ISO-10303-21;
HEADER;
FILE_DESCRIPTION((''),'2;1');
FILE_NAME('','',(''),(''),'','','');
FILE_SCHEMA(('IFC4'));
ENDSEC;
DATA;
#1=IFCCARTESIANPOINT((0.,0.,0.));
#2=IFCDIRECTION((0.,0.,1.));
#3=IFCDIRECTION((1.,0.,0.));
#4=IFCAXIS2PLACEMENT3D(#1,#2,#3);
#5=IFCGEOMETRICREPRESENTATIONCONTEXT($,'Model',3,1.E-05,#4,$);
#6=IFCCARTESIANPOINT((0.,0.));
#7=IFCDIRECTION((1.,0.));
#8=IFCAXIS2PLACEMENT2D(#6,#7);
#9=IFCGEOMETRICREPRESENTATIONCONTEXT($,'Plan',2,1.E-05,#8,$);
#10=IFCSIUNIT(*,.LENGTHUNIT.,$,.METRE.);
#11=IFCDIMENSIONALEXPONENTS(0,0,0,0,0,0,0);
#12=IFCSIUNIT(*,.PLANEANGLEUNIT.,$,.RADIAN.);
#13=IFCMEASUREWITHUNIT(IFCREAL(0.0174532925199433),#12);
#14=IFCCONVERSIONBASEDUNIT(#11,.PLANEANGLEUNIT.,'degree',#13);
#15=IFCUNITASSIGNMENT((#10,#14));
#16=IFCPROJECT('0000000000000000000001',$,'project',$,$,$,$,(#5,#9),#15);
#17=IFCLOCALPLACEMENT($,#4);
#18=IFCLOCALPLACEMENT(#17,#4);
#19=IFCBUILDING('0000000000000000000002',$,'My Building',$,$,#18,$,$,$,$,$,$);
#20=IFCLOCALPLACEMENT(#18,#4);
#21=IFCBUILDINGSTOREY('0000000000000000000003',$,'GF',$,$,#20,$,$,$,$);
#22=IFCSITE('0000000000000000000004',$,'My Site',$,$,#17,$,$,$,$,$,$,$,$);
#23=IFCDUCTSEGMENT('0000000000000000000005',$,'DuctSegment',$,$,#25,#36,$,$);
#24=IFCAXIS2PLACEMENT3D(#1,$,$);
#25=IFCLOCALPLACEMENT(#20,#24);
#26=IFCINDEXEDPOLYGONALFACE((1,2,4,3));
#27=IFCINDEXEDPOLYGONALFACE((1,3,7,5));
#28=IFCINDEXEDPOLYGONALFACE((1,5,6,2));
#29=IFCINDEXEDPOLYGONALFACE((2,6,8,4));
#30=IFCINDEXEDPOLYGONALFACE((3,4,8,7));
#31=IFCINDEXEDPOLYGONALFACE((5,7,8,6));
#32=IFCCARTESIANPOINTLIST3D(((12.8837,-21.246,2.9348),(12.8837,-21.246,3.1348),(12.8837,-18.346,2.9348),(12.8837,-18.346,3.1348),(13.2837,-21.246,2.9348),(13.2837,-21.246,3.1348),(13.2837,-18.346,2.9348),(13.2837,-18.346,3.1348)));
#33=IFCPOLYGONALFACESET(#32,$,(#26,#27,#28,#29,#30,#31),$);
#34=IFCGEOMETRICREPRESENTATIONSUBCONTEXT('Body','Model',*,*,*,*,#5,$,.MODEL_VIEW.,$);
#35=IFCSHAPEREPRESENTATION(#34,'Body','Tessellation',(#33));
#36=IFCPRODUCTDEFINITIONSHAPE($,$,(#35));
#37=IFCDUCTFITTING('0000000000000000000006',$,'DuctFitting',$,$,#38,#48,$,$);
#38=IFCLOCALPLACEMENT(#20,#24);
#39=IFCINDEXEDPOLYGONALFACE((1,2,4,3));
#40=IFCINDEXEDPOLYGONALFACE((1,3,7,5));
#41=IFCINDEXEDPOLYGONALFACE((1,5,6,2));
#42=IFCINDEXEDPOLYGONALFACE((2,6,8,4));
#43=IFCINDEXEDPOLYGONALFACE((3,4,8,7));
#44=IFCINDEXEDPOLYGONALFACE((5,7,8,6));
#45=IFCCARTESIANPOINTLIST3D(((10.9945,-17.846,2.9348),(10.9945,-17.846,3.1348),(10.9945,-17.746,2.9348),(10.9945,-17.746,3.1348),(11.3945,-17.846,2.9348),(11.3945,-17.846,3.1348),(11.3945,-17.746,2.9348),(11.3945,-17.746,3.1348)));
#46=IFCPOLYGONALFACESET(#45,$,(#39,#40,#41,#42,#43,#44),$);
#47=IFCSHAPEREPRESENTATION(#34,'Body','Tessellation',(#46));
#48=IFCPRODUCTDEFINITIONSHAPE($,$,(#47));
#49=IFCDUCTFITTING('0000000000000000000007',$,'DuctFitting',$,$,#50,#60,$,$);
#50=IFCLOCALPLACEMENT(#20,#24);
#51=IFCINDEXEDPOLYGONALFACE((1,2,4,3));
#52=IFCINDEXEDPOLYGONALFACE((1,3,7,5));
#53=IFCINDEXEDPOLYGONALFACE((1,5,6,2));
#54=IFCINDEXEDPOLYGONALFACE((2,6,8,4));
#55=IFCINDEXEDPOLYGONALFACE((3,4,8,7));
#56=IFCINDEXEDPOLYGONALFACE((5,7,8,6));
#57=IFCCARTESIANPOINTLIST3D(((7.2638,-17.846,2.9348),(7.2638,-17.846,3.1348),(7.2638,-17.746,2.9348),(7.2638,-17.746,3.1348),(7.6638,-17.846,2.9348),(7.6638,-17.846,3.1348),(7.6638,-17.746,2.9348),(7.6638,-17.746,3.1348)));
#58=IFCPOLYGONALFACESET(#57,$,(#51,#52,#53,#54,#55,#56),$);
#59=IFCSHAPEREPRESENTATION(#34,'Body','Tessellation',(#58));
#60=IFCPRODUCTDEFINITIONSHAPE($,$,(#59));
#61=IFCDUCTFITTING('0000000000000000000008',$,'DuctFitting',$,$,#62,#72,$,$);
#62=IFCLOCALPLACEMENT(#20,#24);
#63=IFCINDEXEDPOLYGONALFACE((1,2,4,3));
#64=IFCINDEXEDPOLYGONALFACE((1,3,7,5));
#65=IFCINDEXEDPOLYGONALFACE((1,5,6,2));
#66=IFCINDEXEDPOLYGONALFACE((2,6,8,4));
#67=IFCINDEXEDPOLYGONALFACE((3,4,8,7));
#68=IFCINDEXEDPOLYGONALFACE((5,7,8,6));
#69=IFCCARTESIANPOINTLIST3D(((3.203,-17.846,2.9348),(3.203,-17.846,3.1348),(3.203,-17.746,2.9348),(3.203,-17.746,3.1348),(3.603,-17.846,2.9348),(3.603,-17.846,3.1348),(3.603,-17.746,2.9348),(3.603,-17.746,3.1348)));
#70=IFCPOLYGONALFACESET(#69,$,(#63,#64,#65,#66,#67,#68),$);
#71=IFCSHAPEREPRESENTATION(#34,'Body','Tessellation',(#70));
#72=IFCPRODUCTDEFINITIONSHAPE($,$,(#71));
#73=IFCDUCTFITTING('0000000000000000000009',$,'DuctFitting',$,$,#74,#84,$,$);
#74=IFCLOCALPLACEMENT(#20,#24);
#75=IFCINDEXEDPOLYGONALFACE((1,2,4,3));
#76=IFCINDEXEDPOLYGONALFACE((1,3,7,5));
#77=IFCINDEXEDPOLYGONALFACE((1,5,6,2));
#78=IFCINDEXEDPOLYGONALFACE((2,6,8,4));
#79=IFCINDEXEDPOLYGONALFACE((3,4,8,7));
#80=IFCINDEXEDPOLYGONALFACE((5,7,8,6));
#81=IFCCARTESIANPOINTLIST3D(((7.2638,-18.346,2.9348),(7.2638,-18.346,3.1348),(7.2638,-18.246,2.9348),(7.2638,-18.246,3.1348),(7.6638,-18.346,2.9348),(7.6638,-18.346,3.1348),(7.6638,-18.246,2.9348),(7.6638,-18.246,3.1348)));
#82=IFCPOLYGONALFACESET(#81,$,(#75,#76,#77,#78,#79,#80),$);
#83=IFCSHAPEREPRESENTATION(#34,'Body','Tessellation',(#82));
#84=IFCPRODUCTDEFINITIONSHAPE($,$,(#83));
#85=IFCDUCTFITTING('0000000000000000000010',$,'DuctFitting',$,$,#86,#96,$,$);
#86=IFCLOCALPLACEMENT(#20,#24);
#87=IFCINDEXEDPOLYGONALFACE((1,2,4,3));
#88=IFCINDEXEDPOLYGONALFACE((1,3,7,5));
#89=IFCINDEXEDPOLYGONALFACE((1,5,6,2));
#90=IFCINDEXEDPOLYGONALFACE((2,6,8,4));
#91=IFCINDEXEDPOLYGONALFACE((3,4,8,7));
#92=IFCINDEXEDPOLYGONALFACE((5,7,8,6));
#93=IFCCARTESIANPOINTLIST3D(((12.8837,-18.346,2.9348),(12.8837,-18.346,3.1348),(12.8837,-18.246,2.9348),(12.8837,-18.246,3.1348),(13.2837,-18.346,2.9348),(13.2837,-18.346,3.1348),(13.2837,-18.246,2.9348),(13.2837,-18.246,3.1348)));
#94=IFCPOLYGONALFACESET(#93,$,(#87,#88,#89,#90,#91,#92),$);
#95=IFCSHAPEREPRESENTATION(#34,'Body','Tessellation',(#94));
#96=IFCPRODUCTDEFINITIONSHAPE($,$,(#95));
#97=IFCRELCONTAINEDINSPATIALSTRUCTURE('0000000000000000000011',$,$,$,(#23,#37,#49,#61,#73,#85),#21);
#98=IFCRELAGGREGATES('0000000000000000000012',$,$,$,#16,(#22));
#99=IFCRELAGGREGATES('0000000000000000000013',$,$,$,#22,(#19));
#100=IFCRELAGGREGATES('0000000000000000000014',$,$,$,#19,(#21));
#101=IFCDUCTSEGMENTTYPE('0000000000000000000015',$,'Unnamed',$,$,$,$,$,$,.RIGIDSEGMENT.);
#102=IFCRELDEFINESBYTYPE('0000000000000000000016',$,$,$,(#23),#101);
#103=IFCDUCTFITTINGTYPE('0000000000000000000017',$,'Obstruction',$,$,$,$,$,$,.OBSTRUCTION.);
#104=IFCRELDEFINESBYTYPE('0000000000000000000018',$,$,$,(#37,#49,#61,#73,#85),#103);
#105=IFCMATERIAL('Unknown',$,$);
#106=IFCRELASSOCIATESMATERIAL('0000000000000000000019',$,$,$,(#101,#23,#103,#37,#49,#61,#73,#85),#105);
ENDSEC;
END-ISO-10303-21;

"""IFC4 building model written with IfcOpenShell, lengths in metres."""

from ifc_helpers import new_model, entity, si_unit, converted_unit, frame, origin_with_axes, origin_2d_with_axis, place, context, subcontext, project, spatial, rectangle, extrude, material, material_profile, profile_set, profile_usage, type_object, element, save


model = new_model("IFC4")

# Units and contexts
model_context = context("Model", 3, precision=1e-05, world=origin_with_axes())
plan_context = context("Plan", 2, precision=1e-05, world=origin_2d_with_axis())
body_context_1 = subcontext(model_context, "Body", "Model", "MODEL_VIEW")
ifc_project = project(units=[si_unit("LENGTHUNIT", "METRE"), converted_unit("PLANEANGLEUNIT", "degree", entity("IfcReal", 0.0174532925199433), si_unit("PLANEANGLEUNIT", "RADIAN"), dimensions=[0, 0, 0, 0, 0, 0, 0])], contexts=[model_context, plan_context])

# Site, building, storey
site_placement = place(None, origin_with_axes())
site = spatial("IfcSite", under=ifc_project, at=site_placement, Name="My Site")
building_placement = place(site_placement, origin_with_axes())
building = spatial("IfcBuilding", under=site, at=building_placement, Name="My Building")
storey_placement = place(building_placement, origin_with_axes())
storey = spatial("IfcBuildingStorey", under=building, at=storey_placement, Name="GF")

# Shared definitions
ifc_material = material(Name="Unknown")

# Duct segment
ifc_material_profile_1 = material_profile(ifc_material, rectangle(XDim=0.4, YDim=0.2))
ifc_profile_set_1 = profile_set([ifc_material_profile_1])
duct_segment_type = type_object("IfcDuctSegmentType", Name="Unnamed", PredefinedType="RIGIDSEGMENT", material=ifc_profile_set_1)
ifc_profile_usage_1 = profile_usage(ifc_profile_set_1, cardinal=5)
duct_segment_1_placement = place(storey_placement, frame((13.0837, -18.346, 3.0348), z_axis=(0.0, -1.0, 0.000001), x_axis=(1.0, 0.0, 0.0)))
element("IfcDuctSegment", 1, at=duct_segment_1_placement, inside=storey, type_object=duct_segment_type, material=ifc_profile_usage_1, Name="DuctSegment", context=body_context_1, shape_type="SweptSolid", body=[
    extrude(rectangle(XDim=0.4, YDim=0.2), origin_with_axes(), (0.0, 0.0, 1.0), 2.9),
])

# Duct fittings
ifc_material_profile_2 = material_profile(ifc_material, rectangle(XDim=0.4, YDim=0.2))
ifc_profile_set_2 = profile_set([ifc_material_profile_2])
ifc_profile_usage_2 = profile_usage(ifc_profile_set_2, cardinal=5)
duct_fitting_type = type_object("IfcDuctFittingType", Name="Obstruction", PredefinedType="OBSTRUCTION", material=ifc_profile_set_2)
duct_fitting_1_placement = place(storey_placement, frame((11.1945, -17.746, 3.0348), z_axis=(0.0, -1.0, 0.000001), x_axis=(1.0, 0.0, 0.0)))
element("IfcDuctFitting", 2, at=duct_fitting_1_placement, inside=storey, type_object=duct_fitting_type, material=ifc_profile_usage_2, Name="DuctFitting", context=body_context_1, shape_type="SweptSolid", body=[
    extrude(rectangle(XDim=0.4, YDim=0.2), origin_with_axes(), (0.0, 0.0, 1.0), 0.1),
])
ifc_profile_usage_3 = profile_usage(ifc_profile_set_2, cardinal=5)
duct_fitting_2_placement = place(storey_placement, frame((7.4638, -17.746, 3.0348), z_axis=(0.0, -1.0, 0.000001), x_axis=(1.0, 0.0, 0.0)))
element("IfcDuctFitting", 3, at=duct_fitting_2_placement, inside=storey, type_object=duct_fitting_type, material=ifc_profile_usage_3, Name="DuctFitting", context=body_context_1, shape_type="SweptSolid", body=[
    extrude(rectangle(XDim=0.4, YDim=0.2), origin_with_axes(), (0.0, 0.0, 1.0), 0.1),
])
ifc_profile_usage_4 = profile_usage(ifc_profile_set_2, cardinal=5)
duct_fitting_3_placement = place(storey_placement, frame((3.403, -17.746, 3.0348), z_axis=(0.0, -1.0, 0.000001), x_axis=(1.0, 0.0, 0.0)))
element("IfcDuctFitting", 4, at=duct_fitting_3_placement, inside=storey, type_object=duct_fitting_type, material=ifc_profile_usage_4, Name="DuctFitting", context=body_context_1, shape_type="SweptSolid", body=[
    extrude(rectangle(XDim=0.4, YDim=0.2), origin_with_axes(), (0.0, 0.0, 1.0), 0.1),
])
ifc_profile_usage_5 = profile_usage(ifc_profile_set_2, cardinal=5)
duct_fitting_4_placement = place(storey_placement, frame((7.4638, -18.246, 3.0348), z_axis=(0.0, -1.0, 0.000001), x_axis=(1.0, 0.0, 0.0)))
element("IfcDuctFitting", 5, at=duct_fitting_4_placement, inside=storey, type_object=duct_fitting_type, material=ifc_profile_usage_5, Name="DuctFitting", context=body_context_1, shape_type="SweptSolid", body=[
    extrude(rectangle(XDim=0.4, YDim=0.2), origin_with_axes(), (0.0, 0.0, 1.0), 0.1),
])
ifc_profile_usage_6 = profile_usage(ifc_profile_set_2, cardinal=5)
duct_fitting_5_placement = place(storey_placement, frame((13.0837, -18.246, 3.0348), z_axis=(0.0, -1.0, 0.000001), x_axis=(1.0, 0.0, 0.0)))
element("IfcDuctFitting", 6, at=duct_fitting_5_placement, inside=storey, type_object=duct_fitting_type, material=ifc_profile_usage_6, Name="DuctFitting", context=body_context_1, shape_type="SweptSolid", body=[
    extrude(rectangle(XDim=0.4, YDim=0.2), origin_with_axes(), (0.0, 0.0, 1.0), 0.1),
])

save(model, "model.ifc")
